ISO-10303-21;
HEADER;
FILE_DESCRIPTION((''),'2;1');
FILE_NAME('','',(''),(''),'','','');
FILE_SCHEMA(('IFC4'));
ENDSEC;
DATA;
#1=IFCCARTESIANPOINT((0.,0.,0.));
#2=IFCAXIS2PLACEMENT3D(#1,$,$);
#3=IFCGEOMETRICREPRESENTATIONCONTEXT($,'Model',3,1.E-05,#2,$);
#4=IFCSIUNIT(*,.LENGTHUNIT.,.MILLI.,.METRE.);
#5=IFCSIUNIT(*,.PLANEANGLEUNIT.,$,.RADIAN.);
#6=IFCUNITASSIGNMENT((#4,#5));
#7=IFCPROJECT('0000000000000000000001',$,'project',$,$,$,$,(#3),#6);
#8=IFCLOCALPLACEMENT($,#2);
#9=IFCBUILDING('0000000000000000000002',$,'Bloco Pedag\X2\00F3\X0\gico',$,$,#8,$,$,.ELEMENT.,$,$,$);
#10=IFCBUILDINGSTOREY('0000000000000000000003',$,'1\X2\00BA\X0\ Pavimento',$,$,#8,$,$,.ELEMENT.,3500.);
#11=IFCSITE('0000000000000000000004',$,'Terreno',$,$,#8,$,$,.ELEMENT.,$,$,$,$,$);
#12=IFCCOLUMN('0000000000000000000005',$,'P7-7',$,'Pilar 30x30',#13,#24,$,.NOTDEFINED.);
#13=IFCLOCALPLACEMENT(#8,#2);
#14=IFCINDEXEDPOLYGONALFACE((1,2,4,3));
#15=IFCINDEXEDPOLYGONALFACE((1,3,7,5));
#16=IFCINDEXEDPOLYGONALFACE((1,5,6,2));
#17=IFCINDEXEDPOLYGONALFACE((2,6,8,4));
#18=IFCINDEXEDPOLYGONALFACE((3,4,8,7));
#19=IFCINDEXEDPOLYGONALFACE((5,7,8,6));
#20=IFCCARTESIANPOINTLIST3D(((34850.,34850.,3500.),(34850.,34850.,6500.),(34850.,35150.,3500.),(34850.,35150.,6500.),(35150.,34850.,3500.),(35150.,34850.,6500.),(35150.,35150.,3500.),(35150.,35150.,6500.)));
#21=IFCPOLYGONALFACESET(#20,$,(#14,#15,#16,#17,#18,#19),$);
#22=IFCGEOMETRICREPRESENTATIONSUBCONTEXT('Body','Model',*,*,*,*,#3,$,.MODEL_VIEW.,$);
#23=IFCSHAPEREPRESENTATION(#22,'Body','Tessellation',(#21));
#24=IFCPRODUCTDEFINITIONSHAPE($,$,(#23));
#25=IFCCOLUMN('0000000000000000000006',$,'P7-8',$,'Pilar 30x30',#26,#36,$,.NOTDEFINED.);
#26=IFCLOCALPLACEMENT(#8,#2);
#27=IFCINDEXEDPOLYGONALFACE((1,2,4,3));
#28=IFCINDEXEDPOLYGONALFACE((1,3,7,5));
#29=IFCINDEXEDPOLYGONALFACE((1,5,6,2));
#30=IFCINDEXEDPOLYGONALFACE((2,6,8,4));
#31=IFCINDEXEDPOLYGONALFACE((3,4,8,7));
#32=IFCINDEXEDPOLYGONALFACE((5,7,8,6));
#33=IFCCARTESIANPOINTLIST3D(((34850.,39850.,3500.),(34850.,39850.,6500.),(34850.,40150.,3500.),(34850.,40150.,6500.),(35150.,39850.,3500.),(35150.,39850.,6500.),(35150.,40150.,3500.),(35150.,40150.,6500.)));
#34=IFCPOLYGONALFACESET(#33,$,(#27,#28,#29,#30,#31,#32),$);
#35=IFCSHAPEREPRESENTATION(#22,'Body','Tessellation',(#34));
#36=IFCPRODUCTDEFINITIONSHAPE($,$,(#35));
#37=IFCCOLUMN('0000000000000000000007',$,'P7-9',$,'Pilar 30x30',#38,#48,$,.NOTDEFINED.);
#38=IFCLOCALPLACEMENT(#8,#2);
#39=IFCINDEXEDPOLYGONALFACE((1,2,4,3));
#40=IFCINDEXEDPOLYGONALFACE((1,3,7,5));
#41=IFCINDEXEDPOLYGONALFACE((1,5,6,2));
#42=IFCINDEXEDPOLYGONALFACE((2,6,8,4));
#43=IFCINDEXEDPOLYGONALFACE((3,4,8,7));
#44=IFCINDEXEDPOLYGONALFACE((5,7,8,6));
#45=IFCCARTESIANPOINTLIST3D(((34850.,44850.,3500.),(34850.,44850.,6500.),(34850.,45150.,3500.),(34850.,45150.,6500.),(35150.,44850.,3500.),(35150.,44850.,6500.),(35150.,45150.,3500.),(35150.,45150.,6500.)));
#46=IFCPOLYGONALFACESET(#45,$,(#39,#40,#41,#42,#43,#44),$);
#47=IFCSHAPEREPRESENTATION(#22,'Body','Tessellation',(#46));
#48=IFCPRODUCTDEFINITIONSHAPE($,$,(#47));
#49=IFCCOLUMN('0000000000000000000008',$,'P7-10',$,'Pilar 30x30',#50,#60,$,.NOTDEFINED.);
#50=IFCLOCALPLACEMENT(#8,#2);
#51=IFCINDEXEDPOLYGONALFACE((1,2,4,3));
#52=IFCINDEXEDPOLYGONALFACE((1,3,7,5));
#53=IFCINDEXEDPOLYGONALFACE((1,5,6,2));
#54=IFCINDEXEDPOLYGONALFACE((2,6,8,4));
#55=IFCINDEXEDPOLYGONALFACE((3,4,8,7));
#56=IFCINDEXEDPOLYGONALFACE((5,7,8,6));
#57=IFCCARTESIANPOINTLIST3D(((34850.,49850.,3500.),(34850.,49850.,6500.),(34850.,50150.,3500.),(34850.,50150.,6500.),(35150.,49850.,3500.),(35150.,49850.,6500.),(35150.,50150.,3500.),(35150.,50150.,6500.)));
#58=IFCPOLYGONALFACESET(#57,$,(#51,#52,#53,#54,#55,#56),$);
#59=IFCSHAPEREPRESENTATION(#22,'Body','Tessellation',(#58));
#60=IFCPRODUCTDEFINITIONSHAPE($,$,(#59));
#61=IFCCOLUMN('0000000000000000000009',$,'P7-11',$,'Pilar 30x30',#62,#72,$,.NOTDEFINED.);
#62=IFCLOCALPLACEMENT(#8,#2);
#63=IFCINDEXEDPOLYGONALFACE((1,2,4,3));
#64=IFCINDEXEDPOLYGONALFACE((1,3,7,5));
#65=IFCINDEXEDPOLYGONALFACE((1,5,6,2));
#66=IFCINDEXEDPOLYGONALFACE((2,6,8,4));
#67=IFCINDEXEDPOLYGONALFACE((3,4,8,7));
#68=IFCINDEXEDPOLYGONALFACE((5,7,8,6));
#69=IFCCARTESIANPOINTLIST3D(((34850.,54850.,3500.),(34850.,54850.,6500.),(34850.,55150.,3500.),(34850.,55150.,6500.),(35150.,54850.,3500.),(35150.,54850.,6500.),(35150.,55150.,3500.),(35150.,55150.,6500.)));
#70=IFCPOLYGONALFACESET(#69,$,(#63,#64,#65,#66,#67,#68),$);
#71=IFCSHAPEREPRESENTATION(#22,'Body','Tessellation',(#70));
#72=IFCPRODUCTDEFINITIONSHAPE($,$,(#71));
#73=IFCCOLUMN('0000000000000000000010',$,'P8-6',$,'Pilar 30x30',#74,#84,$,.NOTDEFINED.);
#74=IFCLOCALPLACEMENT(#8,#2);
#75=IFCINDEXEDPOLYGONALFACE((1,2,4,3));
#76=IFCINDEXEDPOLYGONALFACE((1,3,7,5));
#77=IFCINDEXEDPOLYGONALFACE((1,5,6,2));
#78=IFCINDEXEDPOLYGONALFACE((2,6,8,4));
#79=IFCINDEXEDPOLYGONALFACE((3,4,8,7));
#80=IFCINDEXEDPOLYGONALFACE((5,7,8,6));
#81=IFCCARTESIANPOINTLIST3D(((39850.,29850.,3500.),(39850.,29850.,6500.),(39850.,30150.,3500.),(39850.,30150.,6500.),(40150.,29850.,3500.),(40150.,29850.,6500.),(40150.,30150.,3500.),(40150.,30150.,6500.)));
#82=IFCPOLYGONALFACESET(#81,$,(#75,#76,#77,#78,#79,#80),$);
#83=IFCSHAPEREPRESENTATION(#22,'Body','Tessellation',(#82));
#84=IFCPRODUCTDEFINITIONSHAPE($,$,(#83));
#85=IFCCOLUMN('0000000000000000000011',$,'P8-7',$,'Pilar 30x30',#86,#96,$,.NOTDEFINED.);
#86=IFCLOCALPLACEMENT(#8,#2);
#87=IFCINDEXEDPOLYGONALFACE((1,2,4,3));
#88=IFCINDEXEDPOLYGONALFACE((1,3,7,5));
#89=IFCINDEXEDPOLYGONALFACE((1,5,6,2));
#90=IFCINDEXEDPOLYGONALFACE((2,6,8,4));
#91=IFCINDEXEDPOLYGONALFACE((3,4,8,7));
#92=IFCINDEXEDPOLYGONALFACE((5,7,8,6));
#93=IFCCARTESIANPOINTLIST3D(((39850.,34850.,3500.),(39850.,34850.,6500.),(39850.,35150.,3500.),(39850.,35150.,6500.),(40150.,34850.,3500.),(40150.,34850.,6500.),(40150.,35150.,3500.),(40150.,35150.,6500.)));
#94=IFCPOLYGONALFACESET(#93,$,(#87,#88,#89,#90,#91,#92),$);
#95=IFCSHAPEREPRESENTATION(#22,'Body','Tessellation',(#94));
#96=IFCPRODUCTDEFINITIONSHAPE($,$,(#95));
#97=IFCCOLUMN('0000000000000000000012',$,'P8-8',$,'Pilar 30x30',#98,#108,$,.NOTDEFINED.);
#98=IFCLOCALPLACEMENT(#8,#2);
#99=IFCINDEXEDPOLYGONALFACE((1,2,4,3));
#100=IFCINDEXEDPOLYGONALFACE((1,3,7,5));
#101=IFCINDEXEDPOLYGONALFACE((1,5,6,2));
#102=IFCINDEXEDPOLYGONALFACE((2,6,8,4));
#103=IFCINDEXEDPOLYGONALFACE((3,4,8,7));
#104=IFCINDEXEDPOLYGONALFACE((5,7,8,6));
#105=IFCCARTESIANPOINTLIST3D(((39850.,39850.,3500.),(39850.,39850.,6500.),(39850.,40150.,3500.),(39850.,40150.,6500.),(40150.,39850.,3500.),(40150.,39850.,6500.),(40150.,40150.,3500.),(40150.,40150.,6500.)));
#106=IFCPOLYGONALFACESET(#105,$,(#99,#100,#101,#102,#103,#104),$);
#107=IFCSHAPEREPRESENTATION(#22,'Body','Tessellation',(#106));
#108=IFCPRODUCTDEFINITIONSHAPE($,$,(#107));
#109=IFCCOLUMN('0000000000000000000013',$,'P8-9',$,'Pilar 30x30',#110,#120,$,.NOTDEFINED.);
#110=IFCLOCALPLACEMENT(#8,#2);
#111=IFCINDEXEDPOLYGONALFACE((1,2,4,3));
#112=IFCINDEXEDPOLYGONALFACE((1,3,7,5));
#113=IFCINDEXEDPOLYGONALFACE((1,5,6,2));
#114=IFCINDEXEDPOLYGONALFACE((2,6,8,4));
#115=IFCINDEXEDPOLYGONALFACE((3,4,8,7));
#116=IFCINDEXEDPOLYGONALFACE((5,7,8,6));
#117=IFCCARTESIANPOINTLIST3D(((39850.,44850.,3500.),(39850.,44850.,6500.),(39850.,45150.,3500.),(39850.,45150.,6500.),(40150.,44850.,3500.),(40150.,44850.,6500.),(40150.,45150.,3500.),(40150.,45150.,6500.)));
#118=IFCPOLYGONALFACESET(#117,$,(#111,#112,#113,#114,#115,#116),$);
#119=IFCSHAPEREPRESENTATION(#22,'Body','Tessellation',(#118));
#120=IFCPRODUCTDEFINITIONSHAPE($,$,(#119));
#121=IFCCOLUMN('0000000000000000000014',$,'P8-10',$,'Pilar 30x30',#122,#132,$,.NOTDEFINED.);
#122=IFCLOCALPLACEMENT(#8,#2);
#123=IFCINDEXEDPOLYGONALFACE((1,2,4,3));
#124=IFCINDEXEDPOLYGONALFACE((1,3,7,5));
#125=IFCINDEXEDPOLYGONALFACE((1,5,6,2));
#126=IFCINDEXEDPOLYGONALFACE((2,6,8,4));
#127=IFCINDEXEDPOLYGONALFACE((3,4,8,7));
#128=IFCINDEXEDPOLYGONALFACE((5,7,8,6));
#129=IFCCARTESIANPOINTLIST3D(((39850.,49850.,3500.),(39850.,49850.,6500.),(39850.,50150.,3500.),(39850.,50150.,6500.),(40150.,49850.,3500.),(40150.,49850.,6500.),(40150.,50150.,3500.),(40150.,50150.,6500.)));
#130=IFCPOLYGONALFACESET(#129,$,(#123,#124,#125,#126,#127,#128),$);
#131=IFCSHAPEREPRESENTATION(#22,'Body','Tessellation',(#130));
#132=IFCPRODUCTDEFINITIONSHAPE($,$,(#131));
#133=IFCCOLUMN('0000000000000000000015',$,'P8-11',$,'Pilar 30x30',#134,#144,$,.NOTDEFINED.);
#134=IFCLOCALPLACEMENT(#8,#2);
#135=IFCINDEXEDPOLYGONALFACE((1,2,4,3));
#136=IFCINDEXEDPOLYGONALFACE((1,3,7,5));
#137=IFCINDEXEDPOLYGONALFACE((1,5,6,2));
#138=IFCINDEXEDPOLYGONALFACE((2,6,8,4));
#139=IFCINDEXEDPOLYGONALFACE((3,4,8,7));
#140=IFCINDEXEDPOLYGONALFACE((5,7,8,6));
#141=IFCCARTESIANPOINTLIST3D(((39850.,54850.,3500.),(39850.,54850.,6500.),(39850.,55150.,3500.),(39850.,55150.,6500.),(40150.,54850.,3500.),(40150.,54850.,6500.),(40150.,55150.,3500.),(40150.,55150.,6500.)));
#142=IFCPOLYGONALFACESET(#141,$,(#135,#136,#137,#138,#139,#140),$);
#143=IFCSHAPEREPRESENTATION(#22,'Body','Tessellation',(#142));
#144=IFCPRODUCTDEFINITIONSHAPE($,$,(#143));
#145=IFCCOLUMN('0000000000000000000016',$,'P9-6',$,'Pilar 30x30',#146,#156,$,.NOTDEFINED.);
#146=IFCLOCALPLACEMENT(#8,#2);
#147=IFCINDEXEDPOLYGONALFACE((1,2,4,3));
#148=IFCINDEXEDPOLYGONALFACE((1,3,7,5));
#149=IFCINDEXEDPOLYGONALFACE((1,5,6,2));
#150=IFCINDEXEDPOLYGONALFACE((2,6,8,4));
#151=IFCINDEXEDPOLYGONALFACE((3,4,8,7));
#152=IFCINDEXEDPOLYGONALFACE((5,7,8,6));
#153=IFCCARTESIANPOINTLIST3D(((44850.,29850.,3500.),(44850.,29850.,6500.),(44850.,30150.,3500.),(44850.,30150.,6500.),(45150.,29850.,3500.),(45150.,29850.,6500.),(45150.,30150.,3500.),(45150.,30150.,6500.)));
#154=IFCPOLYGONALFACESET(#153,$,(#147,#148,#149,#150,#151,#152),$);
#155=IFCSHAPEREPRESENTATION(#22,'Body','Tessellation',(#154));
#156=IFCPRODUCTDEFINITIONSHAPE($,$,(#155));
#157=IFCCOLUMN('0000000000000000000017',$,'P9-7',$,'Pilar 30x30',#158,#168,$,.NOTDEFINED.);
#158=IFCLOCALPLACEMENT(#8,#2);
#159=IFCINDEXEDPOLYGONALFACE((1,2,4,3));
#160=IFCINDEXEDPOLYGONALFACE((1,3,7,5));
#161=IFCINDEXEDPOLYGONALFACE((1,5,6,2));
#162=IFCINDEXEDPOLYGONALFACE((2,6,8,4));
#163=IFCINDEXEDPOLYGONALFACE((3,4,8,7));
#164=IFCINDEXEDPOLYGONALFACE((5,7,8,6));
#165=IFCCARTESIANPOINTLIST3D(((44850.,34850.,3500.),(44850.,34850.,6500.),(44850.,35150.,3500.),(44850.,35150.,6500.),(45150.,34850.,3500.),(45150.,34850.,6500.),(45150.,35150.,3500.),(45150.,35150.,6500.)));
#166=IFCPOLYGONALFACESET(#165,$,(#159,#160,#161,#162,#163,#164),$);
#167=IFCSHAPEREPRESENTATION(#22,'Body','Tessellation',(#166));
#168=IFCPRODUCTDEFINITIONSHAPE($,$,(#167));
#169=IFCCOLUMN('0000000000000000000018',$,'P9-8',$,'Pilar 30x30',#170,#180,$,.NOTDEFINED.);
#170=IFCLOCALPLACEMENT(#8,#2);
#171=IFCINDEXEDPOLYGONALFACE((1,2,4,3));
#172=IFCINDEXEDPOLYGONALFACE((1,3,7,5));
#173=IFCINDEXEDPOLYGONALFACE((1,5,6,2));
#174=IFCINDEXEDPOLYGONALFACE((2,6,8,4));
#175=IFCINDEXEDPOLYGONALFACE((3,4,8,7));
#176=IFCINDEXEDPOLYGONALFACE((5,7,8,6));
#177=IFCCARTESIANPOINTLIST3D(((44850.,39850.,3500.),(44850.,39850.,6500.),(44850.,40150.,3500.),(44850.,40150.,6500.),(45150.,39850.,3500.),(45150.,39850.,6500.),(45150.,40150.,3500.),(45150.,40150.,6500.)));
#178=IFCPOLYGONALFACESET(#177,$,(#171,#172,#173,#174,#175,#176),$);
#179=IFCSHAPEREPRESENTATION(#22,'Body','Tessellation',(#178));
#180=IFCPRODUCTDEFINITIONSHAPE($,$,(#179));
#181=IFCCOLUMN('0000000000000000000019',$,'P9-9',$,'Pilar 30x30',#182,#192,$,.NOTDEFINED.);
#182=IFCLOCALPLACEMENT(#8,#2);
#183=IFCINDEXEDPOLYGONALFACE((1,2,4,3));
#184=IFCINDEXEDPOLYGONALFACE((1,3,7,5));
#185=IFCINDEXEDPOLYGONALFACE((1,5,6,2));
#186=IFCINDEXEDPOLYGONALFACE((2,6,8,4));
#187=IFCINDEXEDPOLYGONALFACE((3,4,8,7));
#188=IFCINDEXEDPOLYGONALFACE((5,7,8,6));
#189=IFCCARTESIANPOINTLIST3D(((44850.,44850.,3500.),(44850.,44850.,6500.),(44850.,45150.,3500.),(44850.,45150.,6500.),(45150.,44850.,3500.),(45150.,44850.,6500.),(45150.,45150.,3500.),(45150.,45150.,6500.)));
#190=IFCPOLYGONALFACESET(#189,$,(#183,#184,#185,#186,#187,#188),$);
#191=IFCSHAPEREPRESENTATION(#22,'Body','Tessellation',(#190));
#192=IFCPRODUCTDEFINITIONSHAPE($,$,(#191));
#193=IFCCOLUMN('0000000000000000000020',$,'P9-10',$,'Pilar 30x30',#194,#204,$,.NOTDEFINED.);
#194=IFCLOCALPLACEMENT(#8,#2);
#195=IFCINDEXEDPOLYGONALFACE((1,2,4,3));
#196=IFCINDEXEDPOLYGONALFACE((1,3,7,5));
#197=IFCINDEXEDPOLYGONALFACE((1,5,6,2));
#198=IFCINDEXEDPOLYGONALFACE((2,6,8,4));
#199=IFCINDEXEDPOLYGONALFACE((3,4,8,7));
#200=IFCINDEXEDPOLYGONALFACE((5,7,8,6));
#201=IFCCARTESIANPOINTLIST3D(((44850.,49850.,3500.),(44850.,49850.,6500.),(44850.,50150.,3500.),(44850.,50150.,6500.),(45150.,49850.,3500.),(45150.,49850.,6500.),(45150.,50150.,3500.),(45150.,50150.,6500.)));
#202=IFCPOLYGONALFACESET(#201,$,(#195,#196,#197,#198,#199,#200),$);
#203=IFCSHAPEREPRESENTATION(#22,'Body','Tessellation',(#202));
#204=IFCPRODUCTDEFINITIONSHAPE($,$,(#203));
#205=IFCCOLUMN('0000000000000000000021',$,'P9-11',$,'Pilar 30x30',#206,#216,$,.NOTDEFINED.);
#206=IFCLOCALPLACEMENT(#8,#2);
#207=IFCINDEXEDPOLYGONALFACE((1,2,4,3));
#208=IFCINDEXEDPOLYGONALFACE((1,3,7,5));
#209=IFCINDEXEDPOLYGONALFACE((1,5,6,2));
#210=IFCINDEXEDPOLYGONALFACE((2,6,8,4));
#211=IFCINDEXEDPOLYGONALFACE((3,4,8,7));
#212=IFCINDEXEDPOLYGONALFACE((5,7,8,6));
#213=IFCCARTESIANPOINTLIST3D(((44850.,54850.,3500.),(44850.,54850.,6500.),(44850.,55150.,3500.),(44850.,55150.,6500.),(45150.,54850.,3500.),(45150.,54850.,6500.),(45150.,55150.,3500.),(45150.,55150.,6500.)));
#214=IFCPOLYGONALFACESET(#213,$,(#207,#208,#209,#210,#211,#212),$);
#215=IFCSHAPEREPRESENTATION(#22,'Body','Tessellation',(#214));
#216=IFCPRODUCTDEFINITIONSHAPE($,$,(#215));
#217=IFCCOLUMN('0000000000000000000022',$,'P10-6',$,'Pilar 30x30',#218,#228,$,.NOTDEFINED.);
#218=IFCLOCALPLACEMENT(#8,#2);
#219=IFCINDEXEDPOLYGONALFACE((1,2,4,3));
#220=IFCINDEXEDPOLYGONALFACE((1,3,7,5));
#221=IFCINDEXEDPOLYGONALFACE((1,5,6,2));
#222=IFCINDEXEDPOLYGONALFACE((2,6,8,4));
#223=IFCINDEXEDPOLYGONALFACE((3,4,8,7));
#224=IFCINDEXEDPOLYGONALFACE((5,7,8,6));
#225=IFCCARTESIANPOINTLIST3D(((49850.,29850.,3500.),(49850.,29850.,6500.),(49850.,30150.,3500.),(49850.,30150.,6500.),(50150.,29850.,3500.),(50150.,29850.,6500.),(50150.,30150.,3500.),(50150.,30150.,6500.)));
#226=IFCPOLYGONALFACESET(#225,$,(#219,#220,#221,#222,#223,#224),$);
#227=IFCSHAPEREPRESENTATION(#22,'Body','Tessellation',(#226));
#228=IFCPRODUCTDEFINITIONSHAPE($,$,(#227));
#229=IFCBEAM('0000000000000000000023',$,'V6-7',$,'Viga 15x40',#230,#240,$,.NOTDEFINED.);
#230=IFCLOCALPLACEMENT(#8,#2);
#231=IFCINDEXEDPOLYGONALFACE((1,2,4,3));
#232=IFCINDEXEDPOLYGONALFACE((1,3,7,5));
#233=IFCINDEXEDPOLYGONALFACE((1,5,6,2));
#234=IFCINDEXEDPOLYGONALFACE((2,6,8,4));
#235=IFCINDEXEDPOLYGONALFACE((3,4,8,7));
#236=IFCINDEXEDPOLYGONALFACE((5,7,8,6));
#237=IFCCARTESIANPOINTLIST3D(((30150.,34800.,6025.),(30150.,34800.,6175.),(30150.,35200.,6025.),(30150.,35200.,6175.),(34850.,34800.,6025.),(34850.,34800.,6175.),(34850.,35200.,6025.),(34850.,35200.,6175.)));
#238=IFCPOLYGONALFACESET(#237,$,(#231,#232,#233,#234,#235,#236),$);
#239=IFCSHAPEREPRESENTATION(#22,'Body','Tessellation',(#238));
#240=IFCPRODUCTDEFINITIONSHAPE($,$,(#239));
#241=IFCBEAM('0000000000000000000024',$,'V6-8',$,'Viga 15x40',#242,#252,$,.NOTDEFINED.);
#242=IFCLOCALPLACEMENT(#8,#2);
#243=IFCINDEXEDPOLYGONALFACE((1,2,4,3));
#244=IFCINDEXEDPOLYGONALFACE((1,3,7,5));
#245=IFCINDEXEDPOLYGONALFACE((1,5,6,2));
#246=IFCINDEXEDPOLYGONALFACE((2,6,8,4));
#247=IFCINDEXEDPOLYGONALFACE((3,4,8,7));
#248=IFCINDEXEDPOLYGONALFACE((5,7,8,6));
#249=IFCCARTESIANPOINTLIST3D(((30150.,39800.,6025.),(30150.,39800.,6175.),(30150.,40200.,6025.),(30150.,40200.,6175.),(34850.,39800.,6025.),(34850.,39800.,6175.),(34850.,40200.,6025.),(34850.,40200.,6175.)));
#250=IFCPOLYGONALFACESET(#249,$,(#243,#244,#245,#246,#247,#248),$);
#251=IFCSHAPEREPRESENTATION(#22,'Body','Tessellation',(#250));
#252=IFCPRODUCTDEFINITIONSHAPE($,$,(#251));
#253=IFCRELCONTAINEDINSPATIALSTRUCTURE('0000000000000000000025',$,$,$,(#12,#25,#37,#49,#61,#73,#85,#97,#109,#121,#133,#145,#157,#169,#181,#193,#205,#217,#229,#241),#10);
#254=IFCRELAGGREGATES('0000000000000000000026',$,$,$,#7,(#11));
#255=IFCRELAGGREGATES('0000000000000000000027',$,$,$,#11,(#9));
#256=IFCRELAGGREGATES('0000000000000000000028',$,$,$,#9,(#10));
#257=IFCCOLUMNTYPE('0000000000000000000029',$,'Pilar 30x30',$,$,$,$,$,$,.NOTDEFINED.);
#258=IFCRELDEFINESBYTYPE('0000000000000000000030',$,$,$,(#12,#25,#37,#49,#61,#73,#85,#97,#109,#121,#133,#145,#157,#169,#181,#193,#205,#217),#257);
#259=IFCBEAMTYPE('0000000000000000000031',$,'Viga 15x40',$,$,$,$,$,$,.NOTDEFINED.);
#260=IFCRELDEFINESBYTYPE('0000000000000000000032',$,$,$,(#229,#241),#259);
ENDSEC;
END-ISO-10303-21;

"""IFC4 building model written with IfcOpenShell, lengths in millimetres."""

from ifc_helpers import new_model, si_unit, frame, origin, origin_2d, place, context, subcontext, project, spatial, rectangle, extrude, type_object, element, save


model = new_model("IFC4")

# Units and contexts
model_context = context("Model", 3, precision=1e-05, world=origin())
body_context = subcontext(model_context, "Body", "Model", "MODEL_VIEW")
ifc_project = project(units=[si_unit("LENGTHUNIT", "METRE", prefix="MILLI"), si_unit("PLANEANGLEUNIT", "RADIAN")], contexts=[model_context])

# Site, building, storey
placement = place(None, origin())
site = spatial("IfcSite", under=ifc_project, at=placement, Name="Terreno", CompositionType="ELEMENT")
building = spatial("IfcBuilding", under=site, at=placement, Name="Bloco Pedagógico", CompositionType="ELEMENT")
storey = spatial("IfcBuildingStorey", under=building, at=placement, Name="1º Pavimento", CompositionType="ELEMENT", Elevation=3500.0)

# Columns
column_type = type_object("IfcColumnType", Name="Pilar 30x30", PredefinedType="NOTDEFINED")
for number, where, z_axis, x_axis, name in (
    (1, (35000.0, 35000.0, 3500.0), (0.0, 0.0, 1.0), (1.0, 0.0, 0.0), "P7-7"),
    (2, (35000.0, 40000.0, 3500.0), (0.0, 0.0, 1.0), (1.0, 0.0, 0.0), "P7-8"),
    (3, (35000.0, 45000.0, 3500.0), (0.0, 0.0, 1.0), (1.0, 0.0, 0.0), "P7-9"),
    (4, (35000.0, 50000.0, 3500.0), (0.0, 0.0, 1.0), (1.0, 0.0, 0.0), "P7-10"),
    (5, (35000.0, 55000.0, 3500.0), (0.0, 0.0, 1.0), (1.0, 0.0, 0.0), "P7-11"),
    (6, (40000.0, 30000.0, 3500.0), (0.0, 0.0, 1.0), (1.0, 0.0, 0.0), "P8-6"),
    (7, (40000.0, 35000.0, 3500.0), (0.0, 0.0, 1.0), (1.0, 0.0, 0.0), "P8-7"),
    (8, (40000.0, 40000.0, 3500.0), (0.0, 0.0, 1.0), (1.0, 0.0, 0.0), "P8-8"),
    (9, (40000.0, 45000.0, 3500.0), (0.0, 0.0, 1.0), (1.0, 0.0, 0.0), "P8-9"),
    (10, (40000.0, 50000.0, 3500.0), (0.0, 0.0, 1.0), (1.0, 0.0, 0.0), "P8-10"),
    (11, (40000.0, 55000.0, 3500.0), (0.0, 0.0, 1.0), (1.0, 0.0, 0.0), "P8-11"),
    (12, (45000.0, 30000.0, 3500.0), (0.0, 0.0, 1.0), (1.0, 0.0, 0.0), "P9-6"),
    (13, (45000.0, 35000.0, 3500.0), (0.0, 0.0, 1.0), (1.0, 0.0, 0.0), "P9-7"),
    (14, (45000.0, 40000.0, 3500.0), (0.0, 0.0, 1.0), (1.0, 0.0, 0.0), "P9-8"),
    (15, (45000.0, 45000.0, 3500.0), (0.0, 0.0, 1.0), (1.0, 0.0, 0.0), "P9-9"),
    (16, (45000.0, 50000.0, 3500.0), (0.0, 0.0, 1.0), (1.0, 0.0, 0.0), "P9-10"),
    (17, (45000.0, 55000.0, 3500.0), (0.0, 0.0, 1.0), (1.0, 0.0, 0.0), "P9-11"),
    (18, (50000.0, 30000.0, 3500.0), (0.0, 0.0, 1.0), (1.0, 0.0, 0.0), "P10-6"),
):
    element("IfcColumn", number, at=place(None, frame(where, z_axis=z_axis, x_axis=x_axis)), inside=storey, type_object=column_type, Name=name, ObjectType="Pilar 30x30", PredefinedType="NOTDEFINED", context=body_context, shape_type="SweptSolid", body=[
        extrude(rectangle(XDim=300.0, YDim=300.0, at=origin_2d()), None, (0.0, 0.0, 1.0), 3000.0),
    ])

# Beams
beam_type = type_object("IfcBeamType", Name="Viga 15x40", PredefinedType="NOTDEFINED")
for number, where, z_axis, x_axis, name in (
    (19, (30150.0, 35000.0, 6100.0), (1.0, 0.0, 0.0), (0.0, 1.0, 0.0), "V6-7"),
    (20, (30150.0, 40000.0, 6100.0), (1.0, 0.0, 0.0), (0.0, 1.0, 0.0), "V6-8"),
):
    element("IfcBeam", number, at=place(None, frame(where, z_axis=z_axis, x_axis=x_axis)), inside=storey, type_object=beam_type, Name=name, ObjectType="Viga 15x40", PredefinedType="NOTDEFINED", context=body_context, shape_type="SweptSolid", body=[
        extrude(rectangle(XDim=400.0, YDim=150.0, at=origin_2d()), None, (0.0, 0.0, 1.0), 4700.0),
    ])

save(model, "model.ifc")
